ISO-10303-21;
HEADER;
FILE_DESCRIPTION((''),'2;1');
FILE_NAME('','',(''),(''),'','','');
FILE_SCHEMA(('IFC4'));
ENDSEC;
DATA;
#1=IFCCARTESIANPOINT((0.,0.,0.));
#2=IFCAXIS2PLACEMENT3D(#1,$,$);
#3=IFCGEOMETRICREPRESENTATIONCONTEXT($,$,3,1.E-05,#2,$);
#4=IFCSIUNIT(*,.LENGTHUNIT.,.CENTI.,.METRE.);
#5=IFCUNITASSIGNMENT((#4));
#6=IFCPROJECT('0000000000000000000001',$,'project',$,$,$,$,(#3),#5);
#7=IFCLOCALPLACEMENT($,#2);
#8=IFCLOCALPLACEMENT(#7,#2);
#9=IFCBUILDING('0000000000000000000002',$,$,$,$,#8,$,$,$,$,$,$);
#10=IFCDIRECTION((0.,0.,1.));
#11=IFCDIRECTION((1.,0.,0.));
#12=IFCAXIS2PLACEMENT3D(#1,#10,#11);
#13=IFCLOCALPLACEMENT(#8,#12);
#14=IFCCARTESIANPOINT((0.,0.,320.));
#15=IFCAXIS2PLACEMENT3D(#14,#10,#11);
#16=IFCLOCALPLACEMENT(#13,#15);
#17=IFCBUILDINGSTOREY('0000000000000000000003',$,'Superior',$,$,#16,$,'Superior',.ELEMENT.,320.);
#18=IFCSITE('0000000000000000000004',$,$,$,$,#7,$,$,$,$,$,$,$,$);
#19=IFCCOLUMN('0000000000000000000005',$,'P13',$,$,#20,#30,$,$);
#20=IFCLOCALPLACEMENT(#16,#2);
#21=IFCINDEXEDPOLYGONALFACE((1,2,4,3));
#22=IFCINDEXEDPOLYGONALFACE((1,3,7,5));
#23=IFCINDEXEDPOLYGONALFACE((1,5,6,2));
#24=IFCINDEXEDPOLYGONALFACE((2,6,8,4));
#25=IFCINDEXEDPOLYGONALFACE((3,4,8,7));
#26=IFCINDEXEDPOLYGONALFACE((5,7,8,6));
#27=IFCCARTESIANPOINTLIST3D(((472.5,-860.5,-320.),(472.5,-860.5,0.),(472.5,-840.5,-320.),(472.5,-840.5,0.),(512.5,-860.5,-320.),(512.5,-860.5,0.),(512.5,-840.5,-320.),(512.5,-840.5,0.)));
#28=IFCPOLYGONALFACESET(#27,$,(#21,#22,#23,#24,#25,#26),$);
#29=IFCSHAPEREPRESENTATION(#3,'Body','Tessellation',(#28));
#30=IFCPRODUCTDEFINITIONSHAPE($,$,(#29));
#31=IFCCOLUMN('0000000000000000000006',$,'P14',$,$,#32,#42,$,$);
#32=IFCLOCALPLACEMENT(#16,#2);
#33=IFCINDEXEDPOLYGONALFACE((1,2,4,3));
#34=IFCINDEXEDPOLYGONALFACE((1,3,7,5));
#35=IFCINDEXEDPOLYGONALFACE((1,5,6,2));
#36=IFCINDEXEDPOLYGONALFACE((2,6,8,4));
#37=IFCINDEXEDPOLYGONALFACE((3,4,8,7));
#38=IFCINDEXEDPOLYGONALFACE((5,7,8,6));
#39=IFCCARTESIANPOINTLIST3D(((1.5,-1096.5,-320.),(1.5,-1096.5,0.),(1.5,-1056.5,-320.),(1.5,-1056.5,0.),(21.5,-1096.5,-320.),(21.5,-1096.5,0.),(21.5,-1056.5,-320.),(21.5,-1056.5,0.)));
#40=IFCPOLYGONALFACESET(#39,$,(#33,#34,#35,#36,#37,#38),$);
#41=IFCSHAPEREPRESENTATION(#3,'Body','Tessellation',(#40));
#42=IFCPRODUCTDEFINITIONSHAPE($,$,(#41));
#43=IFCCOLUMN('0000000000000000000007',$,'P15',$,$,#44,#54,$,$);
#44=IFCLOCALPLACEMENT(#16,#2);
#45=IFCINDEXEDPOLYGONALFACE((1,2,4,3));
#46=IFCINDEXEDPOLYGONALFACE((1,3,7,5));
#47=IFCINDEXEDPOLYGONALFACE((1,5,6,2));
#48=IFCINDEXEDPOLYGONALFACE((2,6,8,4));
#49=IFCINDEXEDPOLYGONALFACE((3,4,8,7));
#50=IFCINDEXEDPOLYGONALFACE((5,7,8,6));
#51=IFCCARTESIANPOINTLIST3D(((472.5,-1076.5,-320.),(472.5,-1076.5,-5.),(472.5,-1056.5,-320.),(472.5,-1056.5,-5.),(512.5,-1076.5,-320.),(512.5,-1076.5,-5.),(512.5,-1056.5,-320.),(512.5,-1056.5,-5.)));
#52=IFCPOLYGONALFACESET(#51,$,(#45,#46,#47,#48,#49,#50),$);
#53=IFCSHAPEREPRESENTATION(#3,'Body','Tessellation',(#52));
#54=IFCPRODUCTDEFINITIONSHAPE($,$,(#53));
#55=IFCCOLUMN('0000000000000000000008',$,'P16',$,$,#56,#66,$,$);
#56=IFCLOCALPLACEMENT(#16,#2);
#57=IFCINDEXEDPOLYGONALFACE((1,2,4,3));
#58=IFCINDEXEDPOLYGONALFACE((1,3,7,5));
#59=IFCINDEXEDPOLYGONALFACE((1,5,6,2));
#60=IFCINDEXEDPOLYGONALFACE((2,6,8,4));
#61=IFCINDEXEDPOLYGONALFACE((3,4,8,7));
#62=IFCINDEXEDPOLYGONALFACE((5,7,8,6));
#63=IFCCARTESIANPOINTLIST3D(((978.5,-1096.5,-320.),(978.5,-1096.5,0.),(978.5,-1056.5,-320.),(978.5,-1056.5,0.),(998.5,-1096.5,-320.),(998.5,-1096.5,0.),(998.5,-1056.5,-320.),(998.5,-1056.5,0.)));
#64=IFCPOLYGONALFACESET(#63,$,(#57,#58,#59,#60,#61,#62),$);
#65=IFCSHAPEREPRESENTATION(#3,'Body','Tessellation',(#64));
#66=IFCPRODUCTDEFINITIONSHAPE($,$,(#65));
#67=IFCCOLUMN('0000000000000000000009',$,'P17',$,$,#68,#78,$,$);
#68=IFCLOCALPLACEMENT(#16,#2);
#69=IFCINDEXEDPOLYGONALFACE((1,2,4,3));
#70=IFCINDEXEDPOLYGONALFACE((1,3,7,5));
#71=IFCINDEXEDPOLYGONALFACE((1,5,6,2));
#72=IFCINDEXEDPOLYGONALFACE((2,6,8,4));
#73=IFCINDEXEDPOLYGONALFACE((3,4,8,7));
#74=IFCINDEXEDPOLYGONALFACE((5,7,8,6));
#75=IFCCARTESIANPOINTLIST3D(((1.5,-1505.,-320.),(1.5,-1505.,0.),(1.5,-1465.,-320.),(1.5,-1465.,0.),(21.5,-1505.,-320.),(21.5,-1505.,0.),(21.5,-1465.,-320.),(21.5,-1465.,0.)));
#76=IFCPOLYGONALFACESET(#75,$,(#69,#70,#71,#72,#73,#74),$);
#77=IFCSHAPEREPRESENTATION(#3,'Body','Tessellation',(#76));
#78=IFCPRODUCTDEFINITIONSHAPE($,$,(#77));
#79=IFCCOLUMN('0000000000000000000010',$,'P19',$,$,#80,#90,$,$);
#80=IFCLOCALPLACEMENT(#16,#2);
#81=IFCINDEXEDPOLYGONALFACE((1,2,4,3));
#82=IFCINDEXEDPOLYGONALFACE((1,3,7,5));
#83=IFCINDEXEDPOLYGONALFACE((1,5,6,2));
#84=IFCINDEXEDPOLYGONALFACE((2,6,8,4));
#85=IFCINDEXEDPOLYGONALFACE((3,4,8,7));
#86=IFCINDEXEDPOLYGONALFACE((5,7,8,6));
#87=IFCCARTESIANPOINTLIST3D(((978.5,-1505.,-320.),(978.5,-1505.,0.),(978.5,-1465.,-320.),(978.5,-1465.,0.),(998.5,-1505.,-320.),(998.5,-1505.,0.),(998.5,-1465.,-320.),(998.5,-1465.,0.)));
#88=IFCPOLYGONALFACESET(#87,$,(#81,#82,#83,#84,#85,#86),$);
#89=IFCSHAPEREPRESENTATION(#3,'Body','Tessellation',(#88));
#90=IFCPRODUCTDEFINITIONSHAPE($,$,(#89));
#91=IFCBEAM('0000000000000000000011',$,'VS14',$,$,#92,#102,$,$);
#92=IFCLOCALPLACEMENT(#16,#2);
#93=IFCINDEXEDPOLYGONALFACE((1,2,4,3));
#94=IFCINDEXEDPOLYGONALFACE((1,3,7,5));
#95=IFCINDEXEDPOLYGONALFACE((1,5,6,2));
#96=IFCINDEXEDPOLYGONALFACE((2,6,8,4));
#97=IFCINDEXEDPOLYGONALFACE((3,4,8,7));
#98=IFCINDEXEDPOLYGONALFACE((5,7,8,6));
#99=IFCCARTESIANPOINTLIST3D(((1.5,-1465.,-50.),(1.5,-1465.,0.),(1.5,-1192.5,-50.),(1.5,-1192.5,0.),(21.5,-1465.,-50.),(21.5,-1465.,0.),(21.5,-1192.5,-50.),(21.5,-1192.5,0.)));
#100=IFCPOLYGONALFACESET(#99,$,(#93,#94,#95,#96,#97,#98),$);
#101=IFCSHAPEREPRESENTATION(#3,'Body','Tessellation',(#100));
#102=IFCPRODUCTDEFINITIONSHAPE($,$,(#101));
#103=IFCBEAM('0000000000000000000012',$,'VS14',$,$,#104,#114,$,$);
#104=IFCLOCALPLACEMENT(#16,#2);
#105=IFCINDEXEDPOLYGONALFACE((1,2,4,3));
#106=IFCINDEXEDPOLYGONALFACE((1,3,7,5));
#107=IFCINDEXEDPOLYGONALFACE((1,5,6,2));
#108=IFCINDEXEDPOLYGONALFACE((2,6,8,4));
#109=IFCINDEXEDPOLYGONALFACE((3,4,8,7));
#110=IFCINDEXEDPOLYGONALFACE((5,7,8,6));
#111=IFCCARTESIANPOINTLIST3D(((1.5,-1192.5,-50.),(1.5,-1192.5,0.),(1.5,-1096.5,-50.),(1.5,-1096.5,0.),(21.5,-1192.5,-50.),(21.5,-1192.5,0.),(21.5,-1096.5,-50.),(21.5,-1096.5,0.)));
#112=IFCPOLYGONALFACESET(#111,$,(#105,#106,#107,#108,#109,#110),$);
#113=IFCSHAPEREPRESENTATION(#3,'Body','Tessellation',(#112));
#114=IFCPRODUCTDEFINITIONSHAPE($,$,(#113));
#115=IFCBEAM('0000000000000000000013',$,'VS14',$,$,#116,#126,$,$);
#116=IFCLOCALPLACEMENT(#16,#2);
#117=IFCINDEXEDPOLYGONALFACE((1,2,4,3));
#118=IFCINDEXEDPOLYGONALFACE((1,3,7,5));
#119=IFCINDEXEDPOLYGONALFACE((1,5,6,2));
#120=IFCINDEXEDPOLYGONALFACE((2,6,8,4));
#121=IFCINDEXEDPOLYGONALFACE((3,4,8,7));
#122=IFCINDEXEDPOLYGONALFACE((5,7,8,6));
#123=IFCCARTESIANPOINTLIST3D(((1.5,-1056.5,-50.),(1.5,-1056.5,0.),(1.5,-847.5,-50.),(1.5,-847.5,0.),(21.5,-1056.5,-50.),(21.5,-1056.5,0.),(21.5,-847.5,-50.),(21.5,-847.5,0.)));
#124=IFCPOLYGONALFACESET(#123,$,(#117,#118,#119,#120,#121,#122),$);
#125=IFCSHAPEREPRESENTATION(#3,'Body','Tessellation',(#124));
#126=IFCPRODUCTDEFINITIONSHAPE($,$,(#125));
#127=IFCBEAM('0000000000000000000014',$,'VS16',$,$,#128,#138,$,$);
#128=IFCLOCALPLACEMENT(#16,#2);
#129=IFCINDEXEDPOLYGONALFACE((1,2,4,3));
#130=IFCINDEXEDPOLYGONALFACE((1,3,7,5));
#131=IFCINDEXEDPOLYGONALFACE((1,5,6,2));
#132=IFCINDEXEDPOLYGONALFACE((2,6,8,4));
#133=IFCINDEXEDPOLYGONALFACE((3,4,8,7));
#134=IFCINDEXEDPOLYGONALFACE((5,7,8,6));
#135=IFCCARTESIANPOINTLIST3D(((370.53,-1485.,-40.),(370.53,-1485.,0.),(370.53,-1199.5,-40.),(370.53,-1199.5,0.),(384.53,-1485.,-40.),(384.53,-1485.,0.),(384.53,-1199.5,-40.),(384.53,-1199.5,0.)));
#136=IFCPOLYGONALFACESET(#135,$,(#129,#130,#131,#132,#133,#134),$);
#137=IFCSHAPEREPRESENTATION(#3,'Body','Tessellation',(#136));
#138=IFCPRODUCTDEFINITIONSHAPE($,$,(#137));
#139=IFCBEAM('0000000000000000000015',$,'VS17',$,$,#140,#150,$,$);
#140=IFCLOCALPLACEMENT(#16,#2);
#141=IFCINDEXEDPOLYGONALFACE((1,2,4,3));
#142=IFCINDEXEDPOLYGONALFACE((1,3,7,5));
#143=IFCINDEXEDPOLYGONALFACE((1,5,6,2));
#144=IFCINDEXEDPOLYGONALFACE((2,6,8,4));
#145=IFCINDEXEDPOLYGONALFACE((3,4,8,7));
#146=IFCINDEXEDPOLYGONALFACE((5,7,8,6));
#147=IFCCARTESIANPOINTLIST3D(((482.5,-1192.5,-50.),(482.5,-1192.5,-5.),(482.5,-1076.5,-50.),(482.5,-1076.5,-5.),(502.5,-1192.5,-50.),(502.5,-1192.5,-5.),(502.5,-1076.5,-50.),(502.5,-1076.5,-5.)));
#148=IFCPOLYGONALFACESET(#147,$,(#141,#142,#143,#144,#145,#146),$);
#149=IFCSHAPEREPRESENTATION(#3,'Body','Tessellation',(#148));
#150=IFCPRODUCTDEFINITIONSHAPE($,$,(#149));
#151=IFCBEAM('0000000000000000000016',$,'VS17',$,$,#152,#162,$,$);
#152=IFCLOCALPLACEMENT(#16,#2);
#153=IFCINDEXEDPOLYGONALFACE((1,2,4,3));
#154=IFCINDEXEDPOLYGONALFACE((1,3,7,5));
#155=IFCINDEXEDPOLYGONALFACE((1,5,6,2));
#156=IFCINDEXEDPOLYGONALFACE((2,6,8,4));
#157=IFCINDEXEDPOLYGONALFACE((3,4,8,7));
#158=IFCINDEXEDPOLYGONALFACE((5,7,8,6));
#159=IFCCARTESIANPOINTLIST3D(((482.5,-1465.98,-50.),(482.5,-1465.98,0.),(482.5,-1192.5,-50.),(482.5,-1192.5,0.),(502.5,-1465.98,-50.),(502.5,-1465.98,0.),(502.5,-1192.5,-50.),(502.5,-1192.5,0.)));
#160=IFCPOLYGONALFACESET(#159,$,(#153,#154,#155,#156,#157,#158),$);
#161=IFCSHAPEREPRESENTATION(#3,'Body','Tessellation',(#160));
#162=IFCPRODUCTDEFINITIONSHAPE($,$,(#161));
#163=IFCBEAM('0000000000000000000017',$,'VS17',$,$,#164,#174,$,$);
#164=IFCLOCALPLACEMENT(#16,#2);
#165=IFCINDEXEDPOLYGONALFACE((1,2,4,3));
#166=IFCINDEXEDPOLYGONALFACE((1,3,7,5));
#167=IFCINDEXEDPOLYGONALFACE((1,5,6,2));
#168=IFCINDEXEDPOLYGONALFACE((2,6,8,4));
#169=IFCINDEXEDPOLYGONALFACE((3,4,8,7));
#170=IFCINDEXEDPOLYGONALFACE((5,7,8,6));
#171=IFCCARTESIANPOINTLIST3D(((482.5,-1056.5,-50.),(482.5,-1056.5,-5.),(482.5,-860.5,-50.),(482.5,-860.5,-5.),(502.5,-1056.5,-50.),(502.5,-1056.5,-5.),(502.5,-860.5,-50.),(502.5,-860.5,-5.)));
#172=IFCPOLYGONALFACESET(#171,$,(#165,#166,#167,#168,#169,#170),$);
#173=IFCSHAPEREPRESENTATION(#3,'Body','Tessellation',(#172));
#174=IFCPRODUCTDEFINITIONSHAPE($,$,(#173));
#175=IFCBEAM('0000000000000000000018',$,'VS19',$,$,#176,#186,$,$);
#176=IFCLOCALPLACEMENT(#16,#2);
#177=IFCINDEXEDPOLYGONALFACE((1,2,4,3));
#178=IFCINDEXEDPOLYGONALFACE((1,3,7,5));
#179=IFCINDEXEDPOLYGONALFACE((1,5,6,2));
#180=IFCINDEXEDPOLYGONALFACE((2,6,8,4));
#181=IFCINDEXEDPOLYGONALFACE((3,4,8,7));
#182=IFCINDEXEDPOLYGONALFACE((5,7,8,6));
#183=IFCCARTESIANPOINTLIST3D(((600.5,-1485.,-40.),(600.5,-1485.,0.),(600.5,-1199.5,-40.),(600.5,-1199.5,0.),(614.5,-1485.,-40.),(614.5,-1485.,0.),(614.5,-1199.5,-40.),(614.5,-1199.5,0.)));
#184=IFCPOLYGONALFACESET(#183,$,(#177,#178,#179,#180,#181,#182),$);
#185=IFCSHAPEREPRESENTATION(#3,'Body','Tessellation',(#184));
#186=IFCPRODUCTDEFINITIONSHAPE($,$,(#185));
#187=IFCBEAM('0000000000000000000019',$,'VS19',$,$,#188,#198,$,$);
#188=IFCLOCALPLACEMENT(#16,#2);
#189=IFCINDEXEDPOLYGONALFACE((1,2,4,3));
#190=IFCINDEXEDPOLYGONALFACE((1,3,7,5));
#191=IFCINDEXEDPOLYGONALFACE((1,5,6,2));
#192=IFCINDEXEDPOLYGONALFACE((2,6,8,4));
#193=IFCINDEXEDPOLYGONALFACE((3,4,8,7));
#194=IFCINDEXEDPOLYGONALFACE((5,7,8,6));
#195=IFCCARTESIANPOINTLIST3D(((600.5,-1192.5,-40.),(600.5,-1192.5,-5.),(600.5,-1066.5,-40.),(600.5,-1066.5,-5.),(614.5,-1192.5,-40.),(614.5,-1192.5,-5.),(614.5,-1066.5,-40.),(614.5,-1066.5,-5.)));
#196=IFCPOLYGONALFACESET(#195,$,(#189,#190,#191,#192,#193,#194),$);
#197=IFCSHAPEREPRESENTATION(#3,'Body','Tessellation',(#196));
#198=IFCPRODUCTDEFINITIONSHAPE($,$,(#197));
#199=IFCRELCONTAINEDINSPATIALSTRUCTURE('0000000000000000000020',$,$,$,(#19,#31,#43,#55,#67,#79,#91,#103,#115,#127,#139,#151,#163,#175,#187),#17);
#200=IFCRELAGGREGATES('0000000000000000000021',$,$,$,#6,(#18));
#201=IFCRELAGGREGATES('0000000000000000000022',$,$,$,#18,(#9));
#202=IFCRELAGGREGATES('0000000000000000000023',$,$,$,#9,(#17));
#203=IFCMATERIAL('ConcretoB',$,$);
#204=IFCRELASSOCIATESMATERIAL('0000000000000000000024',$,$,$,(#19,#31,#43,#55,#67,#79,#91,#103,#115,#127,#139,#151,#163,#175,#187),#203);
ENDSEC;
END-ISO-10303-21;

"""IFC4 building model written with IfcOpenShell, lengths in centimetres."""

from ifc_helpers import new_model, si_unit, frame, origin, origin_with_axes, place, context, project, spatial, polyline, outline, extrude, material, element, save


model = new_model("IFC4")

# Units and contexts
context_of_model = context(None, 3, precision=1e-05, world=origin())
ifc_project = project(units=[si_unit("LENGTHUNIT", "METRE", prefix="CENTI")], contexts=[context_of_model])

# Site, building, storey
site_placement = place(None, origin())
site = spatial("IfcSite", under=ifc_project, at=site_placement)
building_placement = place(site_placement, origin())
building = spatial("IfcBuilding", under=site, at=building_placement)
placement = place(building_placement, origin_with_axes())
storey_placement = place(placement, frame((0.0, 0.0, 320.0), z_axis=(0.0, 0.0, 1.0), x_axis=(1.0, 0.0, 0.0)))
storey = spatial("IfcBuildingStorey", under=building, at=storey_placement, Name="Superior", LongName="Superior", CompositionType="ELEMENT", Elevation=320.0)

# Columns
ifc_material = material(Name="ConcretoB")
column_1_placement = place(storey_placement, frame((492.5, -850.5, 0.0), z_axis=(0.0, 0.0, 1.0), x_axis=(1.0, 0.0, 0.0)))
element("IfcColumn", 1, at=column_1_placement, inside=storey, material=ifc_material, Name="P13", context=context_of_model, shape_type="SolidModel", body=[
    extrude(outline(polyline([(-20.0, 10.0), (-20.0, -10.0), (20.0, -10.0), (20.0, 10.0), (-20.0, 10.0)])), origin_with_axes(), (0.0, 0.0, -1.0), 320.0),
])
column_2_placement = place(storey_placement, frame((11.5, -1076.5, 0.0), z_axis=(0.0, 0.0, 1.0), x_axis=(1.0, 0.0, 0.0)))
element("IfcColumn", 2, at=column_2_placement, inside=storey, material=ifc_material, Name="P14", context=context_of_model, shape_type="SolidModel", body=[
    extrude(outline(polyline([(10.0, 20.0), (-10.0, 20.0), (-10.0, -20.0), (10.0, -20.0), (10.0, 20.0)])), frame((0.0, 0.0, 0.0), z_axis=(0.0, 0.0, 1.0), x_axis=(1.0, 0.0, 0.0)), (0.0, 0.0, -1.0), 320.0),
])
column_3_placement = place(storey_placement, frame((492.5, -1066.5, -5.0), z_axis=(0.0, 0.0, 1.0), x_axis=(1.0, 0.0, 0.0)))
element("IfcColumn", 3, at=column_3_placement, inside=storey, material=ifc_material, Name="P15", context=context_of_model, shape_type="SolidModel", body=[
    extrude(outline(polyline([(-20.0, 10.0), (-20.0, -10.0), (20.0, -10.0), (20.0, 10.0), (-20.0, 10.0)])), origin_with_axes(), (0.0, 0.0, -1.0), 315.0),
])
column_4_placement = place(storey_placement, frame((988.5, -1076.5, 0.0), z_axis=(0.0, 0.0, 1.0), x_axis=(1.0, 0.0, 0.0)))
element("IfcColumn", 4, at=column_4_placement, inside=storey, material=ifc_material, Name="P16", context=context_of_model, shape_type="SolidModel", body=[
    extrude(outline(polyline([(-10.0, -20.0), (10.0, -20.0), (10.0, 20.0), (-10.0, 20.0), (-10.0, -20.0)])), origin_with_axes(), (0.0, 0.0, -1.0), 320.0),
])
column_5_placement = place(storey_placement, frame((11.5, -1485.0, 0.0), z_axis=(0.0, 0.0, 1.0), x_axis=(1.0, 0.0, 0.0)))
element("IfcColumn", 5, at=column_5_placement, inside=storey, material=ifc_material, Name="P17", context=context_of_model, shape_type="SolidModel", body=[
    extrude(outline(polyline([(-10.0, -20.0), (10.0, -20.0), (10.0, 20.0), (-10.0, 20.0), (-10.0, -20.0)])), frame((0.0, 0.0, 0.0), z_axis=(0.0, 0.0, 1.0), x_axis=(1.0, 0.0, 0.0)), (0.0, 0.0, -1.0), 320.0),
])
column_6_placement = place(storey_placement, frame((988.5, -1485.0, 0.0), z_axis=(0.0, 0.0, 1.0), x_axis=(1.0, 0.0, 0.0)))
element("IfcColumn", 6, at=column_6_placement, inside=storey, material=ifc_material, Name="P19", context=context_of_model, shape_type="SolidModel", body=[
    extrude(outline(polyline([(10.0, 20.0), (-10.0, 20.0), (-10.0, -20.0), (10.0, -20.0), (10.0, 20.0)])), origin_with_axes(), (0.0, 0.0, -1.0), 320.0),
])

# Beams
beam_1_placement = place(storey_placement, frame((11.5, -1328.75, 0.0), z_axis=(0.0, 0.0, 1.0), x_axis=(1.0, 0.0, 0.0)))
element("IfcBeam", 7, at=beam_1_placement, inside=storey, material=ifc_material, Name="VS14", context=context_of_model, shape_type="SolidModel", body=[
    extrude(outline(polyline([(-10.0, -25.0), (10.0, -25.0), (10.0, 25.0), (-10.0, 25.0), (-10.0, -25.0)])), frame((0.0, -136.25, -25.0), z_axis=(0.0, 1.0, 0.0), x_axis=(1.0, 0.0, 0.0)), (0.0, 0.0, 1.0), 272.5),
])
beam_2_placement = place(storey_placement, frame((11.5, -1144.5, 0.0), z_axis=(0.0, 0.0, 1.0), x_axis=(1.0, 0.0, 0.0)))
element("IfcBeam", 8, at=beam_2_placement, inside=storey, material=ifc_material, Name="VS14", context=context_of_model, shape_type="SolidModel", body=[
    extrude(outline(polyline([(-10.0, -25.0), (10.0, -25.0), (10.0, 25.0), (-10.0, 25.0), (-10.0, -25.0)])), frame((0.0, -48.0, -25.0), z_axis=(0.0, 1.0, 0.0), x_axis=(1.0, 0.0, 0.0)), (0.0, 0.0, 1.0), 96.0),
])
beam_3_placement = place(storey_placement, frame((11.5, -952.0, 0.0), z_axis=(0.0, 0.0, 1.0), x_axis=(1.0, 0.0, 0.0)))
element("IfcBeam", 9, at=beam_3_placement, inside=storey, material=ifc_material, Name="VS14", context=context_of_model, shape_type="SolidModel", body=[
    extrude(outline(polyline([(-10.0, -25.0), (10.0, -25.0), (10.0, 25.0), (-10.0, 25.0), (-10.0, -25.0)])), frame((0.0, -104.5, -25.0), z_axis=(0.0, 1.0, 0.0), x_axis=(1.0, 0.0, 0.0)), (0.0, 0.0, 1.0), 209.0),
])
beam_4_placement = place(storey_placement, frame((377.53, -1342.25, 0.0), z_axis=(0.0, 0.0, 1.0), x_axis=(1.0, 0.0, 0.0)))
element("IfcBeam", 10, at=beam_4_placement, inside=storey, material=ifc_material, Name="VS16", context=context_of_model, shape_type="SolidModel", body=[
    extrude(outline(polyline([(-7.0, -20.0), (7.0, -20.0), (7.0, 20.0), (-7.0, 20.0), (-7.0, -20.0)])), frame((0.0, -142.75, -20.0), z_axis=(0.0, 1.0, 0.0), x_axis=(1.0, 0.0, 0.0)), (0.0, 0.0, 1.0), 285.5),
])
beam_5_placement = place(storey_placement, frame((492.5, -1134.5, -5.0), z_axis=(0.0, 0.0, 1.0), x_axis=(1.0, 0.0, 0.0)))
element("IfcBeam", 11, at=beam_5_placement, inside=storey, material=ifc_material, Name="VS17", context=context_of_model, shape_type="SolidModel", body=[
    extrude(outline(polyline([(-10.0, -22.5), (10.0, -22.5), (10.0, 22.5), (-10.0, 22.5), (-10.0, -22.5)])), frame((0.0, -58.0, -22.5), z_axis=(0.0, 1.0, 0.0), x_axis=(1.0, 0.0, 0.0)), (0.0, 0.0, 1.0), 116.0),
])
beam_6_placement = place(storey_placement, frame((492.5, -1329.24, 0.0), z_axis=(0.0, 0.0, 1.0), x_axis=(1.0, 0.0, 0.0)))
element("IfcBeam", 12, at=beam_6_placement, inside=storey, material=ifc_material, Name="VS17", context=context_of_model, shape_type="SolidModel", body=[
    extrude(outline(polyline([(-10.0, -25.0), (10.0, -25.0), (10.0, 25.0), (-10.0, 25.0), (-10.0, -25.0)])), frame((0.0, -136.75, -25.0), z_axis=(0.0, 1.0, 0.0), x_axis=(1.0, 0.0, 0.0)), (0.0, 0.0, 1.0), 273.49),
])
beam_7_placement = place(storey_placement, frame((492.5, -958.5, -5.0), z_axis=(0.0, 0.0, 1.0), x_axis=(1.0, 0.0, 0.0)))
element("IfcBeam", 13, at=beam_7_placement, inside=storey, material=ifc_material, Name="VS17", context=context_of_model, shape_type="SolidModel", body=[
    extrude(outline(polyline([(-10.0, -22.5), (10.0, -22.5), (10.0, 22.5), (-10.0, 22.5), (-10.0, -22.5)])), frame((0.0, -98.0, -22.5), z_axis=(0.0, 1.0, 0.0), x_axis=(1.0, 0.0, 0.0)), (0.0, 0.0, 1.0), 196.0),
])
beam_8_placement = place(storey_placement, frame((607.5, -1342.25, 0.0), z_axis=(0.0, 0.0, 1.0), x_axis=(1.0, 0.0, 0.0)))
element("IfcBeam", 14, at=beam_8_placement, inside=storey, material=ifc_material, Name="VS19", context=context_of_model, shape_type="SolidModel", body=[
    extrude(outline(polyline([(-7.0, -20.0), (7.0, -20.0), (7.0, 20.0), (-7.0, 20.0), (-7.0, -20.0)])), frame((0.0, -142.75, -20.0), z_axis=(0.0, 1.0, 0.0), x_axis=(1.0, 0.0, 0.0)), (0.0, 0.0, 1.0), 285.5),
])
beam_9_placement = place(storey_placement, frame((607.5, -1129.5, -5.0), z_axis=(0.0, 0.0, 1.0), x_axis=(1.0, 0.0, 0.0)))
element("IfcBeam", 15, at=beam_9_placement, inside=storey, material=ifc_material, Name="VS19", context=context_of_model, shape_type="SolidModel", body=[
    extrude(outline(polyline([(-7.0, -17.5), (7.0, -17.5), (7.0, 17.5), (-7.0, 17.5), (-7.0, -17.5)])), frame((0.0, -63.0, -17.5), z_axis=(0.0, 1.0, 0.0), x_axis=(1.0, 0.0, 0.0)), (0.0, 0.0, 1.0), 126.0),
])

save(model, "model.ifc")
